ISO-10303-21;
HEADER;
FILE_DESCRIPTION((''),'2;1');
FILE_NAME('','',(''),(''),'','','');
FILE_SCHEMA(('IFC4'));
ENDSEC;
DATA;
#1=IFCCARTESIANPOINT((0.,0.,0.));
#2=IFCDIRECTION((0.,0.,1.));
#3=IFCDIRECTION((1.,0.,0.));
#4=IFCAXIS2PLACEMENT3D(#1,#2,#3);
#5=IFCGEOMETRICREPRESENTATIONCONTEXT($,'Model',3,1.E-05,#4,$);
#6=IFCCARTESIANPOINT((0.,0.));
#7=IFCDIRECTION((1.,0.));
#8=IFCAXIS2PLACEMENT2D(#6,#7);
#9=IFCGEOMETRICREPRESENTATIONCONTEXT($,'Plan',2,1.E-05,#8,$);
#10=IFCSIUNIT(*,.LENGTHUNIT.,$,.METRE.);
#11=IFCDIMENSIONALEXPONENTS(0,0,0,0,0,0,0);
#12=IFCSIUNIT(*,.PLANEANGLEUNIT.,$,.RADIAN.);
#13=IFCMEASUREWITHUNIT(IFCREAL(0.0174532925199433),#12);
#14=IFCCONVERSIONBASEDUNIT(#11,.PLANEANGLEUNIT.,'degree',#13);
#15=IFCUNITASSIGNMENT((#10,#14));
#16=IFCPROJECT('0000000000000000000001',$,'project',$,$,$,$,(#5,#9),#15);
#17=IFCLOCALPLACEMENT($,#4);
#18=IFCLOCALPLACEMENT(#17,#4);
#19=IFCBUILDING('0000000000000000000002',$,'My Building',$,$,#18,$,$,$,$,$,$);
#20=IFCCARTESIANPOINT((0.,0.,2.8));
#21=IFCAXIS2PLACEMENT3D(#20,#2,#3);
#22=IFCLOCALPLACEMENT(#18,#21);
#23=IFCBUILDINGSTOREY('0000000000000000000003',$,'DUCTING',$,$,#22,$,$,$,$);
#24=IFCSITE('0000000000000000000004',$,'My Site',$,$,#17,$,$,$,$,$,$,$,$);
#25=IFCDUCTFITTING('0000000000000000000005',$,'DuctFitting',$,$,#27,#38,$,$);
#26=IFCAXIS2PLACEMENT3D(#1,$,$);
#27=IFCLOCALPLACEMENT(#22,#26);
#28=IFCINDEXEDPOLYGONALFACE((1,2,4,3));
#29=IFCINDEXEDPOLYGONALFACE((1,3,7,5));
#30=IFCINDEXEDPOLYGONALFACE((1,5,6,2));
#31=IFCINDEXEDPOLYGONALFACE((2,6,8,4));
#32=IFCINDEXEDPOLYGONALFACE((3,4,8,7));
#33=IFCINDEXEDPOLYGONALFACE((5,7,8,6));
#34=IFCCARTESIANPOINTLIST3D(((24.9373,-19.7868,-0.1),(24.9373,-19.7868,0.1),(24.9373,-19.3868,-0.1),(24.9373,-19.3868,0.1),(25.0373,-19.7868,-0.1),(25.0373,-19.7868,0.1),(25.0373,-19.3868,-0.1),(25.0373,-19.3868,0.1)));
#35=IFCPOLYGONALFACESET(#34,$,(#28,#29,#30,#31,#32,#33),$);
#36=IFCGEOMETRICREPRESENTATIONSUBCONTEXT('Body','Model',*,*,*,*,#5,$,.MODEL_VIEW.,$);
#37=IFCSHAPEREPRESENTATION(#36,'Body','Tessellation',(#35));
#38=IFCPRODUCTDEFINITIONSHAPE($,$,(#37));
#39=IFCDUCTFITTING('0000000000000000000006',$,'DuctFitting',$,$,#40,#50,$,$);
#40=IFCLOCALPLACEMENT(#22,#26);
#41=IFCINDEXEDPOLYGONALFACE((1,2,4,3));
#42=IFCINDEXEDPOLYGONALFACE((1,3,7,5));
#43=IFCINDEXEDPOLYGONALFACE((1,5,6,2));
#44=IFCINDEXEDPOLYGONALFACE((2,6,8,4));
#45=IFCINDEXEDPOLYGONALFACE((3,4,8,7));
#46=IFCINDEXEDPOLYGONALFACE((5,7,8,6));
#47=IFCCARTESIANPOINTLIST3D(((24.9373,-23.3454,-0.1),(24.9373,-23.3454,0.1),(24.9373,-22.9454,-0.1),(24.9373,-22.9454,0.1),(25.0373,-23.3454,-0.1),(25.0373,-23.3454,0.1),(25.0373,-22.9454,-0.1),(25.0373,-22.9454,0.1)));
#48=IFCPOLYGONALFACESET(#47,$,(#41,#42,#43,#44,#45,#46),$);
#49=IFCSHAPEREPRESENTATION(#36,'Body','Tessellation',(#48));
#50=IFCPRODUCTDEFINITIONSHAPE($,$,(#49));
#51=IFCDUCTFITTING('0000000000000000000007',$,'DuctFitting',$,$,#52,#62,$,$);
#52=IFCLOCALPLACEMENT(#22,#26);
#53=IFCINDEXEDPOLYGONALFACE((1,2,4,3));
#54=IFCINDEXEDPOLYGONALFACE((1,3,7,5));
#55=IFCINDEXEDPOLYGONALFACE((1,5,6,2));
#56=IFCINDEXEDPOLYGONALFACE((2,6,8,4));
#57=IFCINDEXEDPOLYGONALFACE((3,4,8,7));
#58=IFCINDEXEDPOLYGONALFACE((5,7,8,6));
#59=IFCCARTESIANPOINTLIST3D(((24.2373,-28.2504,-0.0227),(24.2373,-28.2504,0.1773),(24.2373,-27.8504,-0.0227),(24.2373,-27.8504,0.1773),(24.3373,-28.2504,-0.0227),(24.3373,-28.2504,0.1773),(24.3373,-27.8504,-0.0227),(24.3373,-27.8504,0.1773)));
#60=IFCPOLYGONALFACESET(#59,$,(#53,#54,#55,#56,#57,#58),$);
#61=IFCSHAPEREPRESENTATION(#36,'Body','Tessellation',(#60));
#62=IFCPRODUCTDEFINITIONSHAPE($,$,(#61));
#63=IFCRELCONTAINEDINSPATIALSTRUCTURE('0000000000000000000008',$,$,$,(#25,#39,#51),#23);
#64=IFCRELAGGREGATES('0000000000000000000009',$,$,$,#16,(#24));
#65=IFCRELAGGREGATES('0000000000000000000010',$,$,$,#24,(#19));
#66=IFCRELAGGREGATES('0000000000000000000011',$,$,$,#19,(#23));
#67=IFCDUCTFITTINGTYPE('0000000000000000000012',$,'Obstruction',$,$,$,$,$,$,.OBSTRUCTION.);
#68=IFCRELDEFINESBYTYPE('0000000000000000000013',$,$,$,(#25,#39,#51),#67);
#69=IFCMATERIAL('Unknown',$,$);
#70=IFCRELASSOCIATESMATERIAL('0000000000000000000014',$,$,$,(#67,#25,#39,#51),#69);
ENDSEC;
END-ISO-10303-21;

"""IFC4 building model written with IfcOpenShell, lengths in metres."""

from ifc_helpers import new_model, entity, si_unit, converted_unit, frame, origin_with_axes, origin_2d_with_axis, place, context, subcontext, project, spatial, rectangle, extrude, material, material_profile, profile_set, profile_usage, type_object, element, save


model = new_model("IFC4")

# Units and contexts
model_context = context("Model", 3, precision=1e-05, world=origin_with_axes())
plan_context = context("Plan", 2, precision=1e-05, world=origin_2d_with_axis())
body_context = subcontext(model_context, "Body", "Model", "MODEL_VIEW")
ifc_project = project(units=[si_unit("LENGTHUNIT", "METRE"), converted_unit("PLANEANGLEUNIT", "degree", entity("IfcReal", 0.0174532925199433), si_unit("PLANEANGLEUNIT", "RADIAN"), dimensions=[0, 0, 0, 0, 0, 0, 0])], contexts=[model_context, plan_context])

# Site, building, storey
site_placement = place(None, origin_with_axes())
site = spatial("IfcSite", under=ifc_project, at=site_placement, Name="My Site")
building_placement = place(site_placement, origin_with_axes())
building = spatial("IfcBuilding", under=site, at=building_placement, Name="My Building")
storey_placement = place(building_placement, frame((0.0, 0.0, 2.8), z_axis=(0.0, 0.0, 1.0), x_axis=(1.0, 0.0, 0.0)))
storey = spatial("IfcBuildingStorey", under=building, at=storey_placement, Name="DUCTING")

# Shared definitions
ifc_material = material(Name="Unknown")

# Duct fittings
ifc_material_profile_1 = material_profile(ifc_material, rectangle(XDim=0.4, YDim=0.2))
ifc_profile_set_1 = profile_set([ifc_material_profile_1])
duct_fitting_type_1 = type_object("IfcDuctFittingType", Name="Obstruction", PredefinedType="OBSTRUCTION", material=ifc_profile_set_1)
ifc_profile_usage_1 = profile_usage(ifc_profile_set_1, cardinal=5)
duct_fitting_1_placement = place(storey_placement, frame((24.9373, -19.5868, 0.0), z_axis=(1.0, 0.0, 0.0), x_axis=(0.0, 1.0, 0.0)))
element("IfcDuctFitting", 1, at=duct_fitting_1_placement, inside=storey, type_object=duct_fitting_type_1, material=ifc_profile_usage_1, Name="DuctFitting", context=body_context, shape_type="SweptSolid", body=[
    extrude(rectangle(XDim=0.4, YDim=0.2), origin_with_axes(), (0.0, 0.0, 1.0), 0.1),
])
ifc_profile_usage_2 = profile_usage(ifc_profile_set_1, cardinal=5)
duct_fitting_2_placement = place(storey_placement, frame((24.9373, -23.1454, 0.0), z_axis=(1.0, 0.0, 0.0), x_axis=(0.0, 1.0, 0.0)))
element("IfcDuctFitting", 2, at=duct_fitting_2_placement, inside=storey, type_object=duct_fitting_type_1, material=ifc_profile_usage_2, Name="DuctFitting", context=body_context, shape_type="SweptSolid", body=[
    extrude(rectangle(XDim=0.4, YDim=0.2), origin_with_axes(), (0.0, 0.0, 1.0), 0.1),
])
ifc_profile_usage_3 = profile_usage(ifc_profile_set_1, cardinal=5)
duct_fitting_3_placement = place(storey_placement, frame((24.2373, -28.0504, 0.0773), z_axis=(1.0, 0.0, 0.0), x_axis=(0.0, 1.0, 0.0)))
element("IfcDuctFitting", 3, at=duct_fitting_3_placement, inside=storey, type_object=duct_fitting_type_1, material=ifc_profile_usage_3, Name="DuctFitting", context=body_context, shape_type="SweptSolid", body=[
    extrude(rectangle(XDim=0.4, YDim=0.2), origin_with_axes(), (0.0, 0.0, 1.0), 0.1),
])

save(model, "model.ifc")
